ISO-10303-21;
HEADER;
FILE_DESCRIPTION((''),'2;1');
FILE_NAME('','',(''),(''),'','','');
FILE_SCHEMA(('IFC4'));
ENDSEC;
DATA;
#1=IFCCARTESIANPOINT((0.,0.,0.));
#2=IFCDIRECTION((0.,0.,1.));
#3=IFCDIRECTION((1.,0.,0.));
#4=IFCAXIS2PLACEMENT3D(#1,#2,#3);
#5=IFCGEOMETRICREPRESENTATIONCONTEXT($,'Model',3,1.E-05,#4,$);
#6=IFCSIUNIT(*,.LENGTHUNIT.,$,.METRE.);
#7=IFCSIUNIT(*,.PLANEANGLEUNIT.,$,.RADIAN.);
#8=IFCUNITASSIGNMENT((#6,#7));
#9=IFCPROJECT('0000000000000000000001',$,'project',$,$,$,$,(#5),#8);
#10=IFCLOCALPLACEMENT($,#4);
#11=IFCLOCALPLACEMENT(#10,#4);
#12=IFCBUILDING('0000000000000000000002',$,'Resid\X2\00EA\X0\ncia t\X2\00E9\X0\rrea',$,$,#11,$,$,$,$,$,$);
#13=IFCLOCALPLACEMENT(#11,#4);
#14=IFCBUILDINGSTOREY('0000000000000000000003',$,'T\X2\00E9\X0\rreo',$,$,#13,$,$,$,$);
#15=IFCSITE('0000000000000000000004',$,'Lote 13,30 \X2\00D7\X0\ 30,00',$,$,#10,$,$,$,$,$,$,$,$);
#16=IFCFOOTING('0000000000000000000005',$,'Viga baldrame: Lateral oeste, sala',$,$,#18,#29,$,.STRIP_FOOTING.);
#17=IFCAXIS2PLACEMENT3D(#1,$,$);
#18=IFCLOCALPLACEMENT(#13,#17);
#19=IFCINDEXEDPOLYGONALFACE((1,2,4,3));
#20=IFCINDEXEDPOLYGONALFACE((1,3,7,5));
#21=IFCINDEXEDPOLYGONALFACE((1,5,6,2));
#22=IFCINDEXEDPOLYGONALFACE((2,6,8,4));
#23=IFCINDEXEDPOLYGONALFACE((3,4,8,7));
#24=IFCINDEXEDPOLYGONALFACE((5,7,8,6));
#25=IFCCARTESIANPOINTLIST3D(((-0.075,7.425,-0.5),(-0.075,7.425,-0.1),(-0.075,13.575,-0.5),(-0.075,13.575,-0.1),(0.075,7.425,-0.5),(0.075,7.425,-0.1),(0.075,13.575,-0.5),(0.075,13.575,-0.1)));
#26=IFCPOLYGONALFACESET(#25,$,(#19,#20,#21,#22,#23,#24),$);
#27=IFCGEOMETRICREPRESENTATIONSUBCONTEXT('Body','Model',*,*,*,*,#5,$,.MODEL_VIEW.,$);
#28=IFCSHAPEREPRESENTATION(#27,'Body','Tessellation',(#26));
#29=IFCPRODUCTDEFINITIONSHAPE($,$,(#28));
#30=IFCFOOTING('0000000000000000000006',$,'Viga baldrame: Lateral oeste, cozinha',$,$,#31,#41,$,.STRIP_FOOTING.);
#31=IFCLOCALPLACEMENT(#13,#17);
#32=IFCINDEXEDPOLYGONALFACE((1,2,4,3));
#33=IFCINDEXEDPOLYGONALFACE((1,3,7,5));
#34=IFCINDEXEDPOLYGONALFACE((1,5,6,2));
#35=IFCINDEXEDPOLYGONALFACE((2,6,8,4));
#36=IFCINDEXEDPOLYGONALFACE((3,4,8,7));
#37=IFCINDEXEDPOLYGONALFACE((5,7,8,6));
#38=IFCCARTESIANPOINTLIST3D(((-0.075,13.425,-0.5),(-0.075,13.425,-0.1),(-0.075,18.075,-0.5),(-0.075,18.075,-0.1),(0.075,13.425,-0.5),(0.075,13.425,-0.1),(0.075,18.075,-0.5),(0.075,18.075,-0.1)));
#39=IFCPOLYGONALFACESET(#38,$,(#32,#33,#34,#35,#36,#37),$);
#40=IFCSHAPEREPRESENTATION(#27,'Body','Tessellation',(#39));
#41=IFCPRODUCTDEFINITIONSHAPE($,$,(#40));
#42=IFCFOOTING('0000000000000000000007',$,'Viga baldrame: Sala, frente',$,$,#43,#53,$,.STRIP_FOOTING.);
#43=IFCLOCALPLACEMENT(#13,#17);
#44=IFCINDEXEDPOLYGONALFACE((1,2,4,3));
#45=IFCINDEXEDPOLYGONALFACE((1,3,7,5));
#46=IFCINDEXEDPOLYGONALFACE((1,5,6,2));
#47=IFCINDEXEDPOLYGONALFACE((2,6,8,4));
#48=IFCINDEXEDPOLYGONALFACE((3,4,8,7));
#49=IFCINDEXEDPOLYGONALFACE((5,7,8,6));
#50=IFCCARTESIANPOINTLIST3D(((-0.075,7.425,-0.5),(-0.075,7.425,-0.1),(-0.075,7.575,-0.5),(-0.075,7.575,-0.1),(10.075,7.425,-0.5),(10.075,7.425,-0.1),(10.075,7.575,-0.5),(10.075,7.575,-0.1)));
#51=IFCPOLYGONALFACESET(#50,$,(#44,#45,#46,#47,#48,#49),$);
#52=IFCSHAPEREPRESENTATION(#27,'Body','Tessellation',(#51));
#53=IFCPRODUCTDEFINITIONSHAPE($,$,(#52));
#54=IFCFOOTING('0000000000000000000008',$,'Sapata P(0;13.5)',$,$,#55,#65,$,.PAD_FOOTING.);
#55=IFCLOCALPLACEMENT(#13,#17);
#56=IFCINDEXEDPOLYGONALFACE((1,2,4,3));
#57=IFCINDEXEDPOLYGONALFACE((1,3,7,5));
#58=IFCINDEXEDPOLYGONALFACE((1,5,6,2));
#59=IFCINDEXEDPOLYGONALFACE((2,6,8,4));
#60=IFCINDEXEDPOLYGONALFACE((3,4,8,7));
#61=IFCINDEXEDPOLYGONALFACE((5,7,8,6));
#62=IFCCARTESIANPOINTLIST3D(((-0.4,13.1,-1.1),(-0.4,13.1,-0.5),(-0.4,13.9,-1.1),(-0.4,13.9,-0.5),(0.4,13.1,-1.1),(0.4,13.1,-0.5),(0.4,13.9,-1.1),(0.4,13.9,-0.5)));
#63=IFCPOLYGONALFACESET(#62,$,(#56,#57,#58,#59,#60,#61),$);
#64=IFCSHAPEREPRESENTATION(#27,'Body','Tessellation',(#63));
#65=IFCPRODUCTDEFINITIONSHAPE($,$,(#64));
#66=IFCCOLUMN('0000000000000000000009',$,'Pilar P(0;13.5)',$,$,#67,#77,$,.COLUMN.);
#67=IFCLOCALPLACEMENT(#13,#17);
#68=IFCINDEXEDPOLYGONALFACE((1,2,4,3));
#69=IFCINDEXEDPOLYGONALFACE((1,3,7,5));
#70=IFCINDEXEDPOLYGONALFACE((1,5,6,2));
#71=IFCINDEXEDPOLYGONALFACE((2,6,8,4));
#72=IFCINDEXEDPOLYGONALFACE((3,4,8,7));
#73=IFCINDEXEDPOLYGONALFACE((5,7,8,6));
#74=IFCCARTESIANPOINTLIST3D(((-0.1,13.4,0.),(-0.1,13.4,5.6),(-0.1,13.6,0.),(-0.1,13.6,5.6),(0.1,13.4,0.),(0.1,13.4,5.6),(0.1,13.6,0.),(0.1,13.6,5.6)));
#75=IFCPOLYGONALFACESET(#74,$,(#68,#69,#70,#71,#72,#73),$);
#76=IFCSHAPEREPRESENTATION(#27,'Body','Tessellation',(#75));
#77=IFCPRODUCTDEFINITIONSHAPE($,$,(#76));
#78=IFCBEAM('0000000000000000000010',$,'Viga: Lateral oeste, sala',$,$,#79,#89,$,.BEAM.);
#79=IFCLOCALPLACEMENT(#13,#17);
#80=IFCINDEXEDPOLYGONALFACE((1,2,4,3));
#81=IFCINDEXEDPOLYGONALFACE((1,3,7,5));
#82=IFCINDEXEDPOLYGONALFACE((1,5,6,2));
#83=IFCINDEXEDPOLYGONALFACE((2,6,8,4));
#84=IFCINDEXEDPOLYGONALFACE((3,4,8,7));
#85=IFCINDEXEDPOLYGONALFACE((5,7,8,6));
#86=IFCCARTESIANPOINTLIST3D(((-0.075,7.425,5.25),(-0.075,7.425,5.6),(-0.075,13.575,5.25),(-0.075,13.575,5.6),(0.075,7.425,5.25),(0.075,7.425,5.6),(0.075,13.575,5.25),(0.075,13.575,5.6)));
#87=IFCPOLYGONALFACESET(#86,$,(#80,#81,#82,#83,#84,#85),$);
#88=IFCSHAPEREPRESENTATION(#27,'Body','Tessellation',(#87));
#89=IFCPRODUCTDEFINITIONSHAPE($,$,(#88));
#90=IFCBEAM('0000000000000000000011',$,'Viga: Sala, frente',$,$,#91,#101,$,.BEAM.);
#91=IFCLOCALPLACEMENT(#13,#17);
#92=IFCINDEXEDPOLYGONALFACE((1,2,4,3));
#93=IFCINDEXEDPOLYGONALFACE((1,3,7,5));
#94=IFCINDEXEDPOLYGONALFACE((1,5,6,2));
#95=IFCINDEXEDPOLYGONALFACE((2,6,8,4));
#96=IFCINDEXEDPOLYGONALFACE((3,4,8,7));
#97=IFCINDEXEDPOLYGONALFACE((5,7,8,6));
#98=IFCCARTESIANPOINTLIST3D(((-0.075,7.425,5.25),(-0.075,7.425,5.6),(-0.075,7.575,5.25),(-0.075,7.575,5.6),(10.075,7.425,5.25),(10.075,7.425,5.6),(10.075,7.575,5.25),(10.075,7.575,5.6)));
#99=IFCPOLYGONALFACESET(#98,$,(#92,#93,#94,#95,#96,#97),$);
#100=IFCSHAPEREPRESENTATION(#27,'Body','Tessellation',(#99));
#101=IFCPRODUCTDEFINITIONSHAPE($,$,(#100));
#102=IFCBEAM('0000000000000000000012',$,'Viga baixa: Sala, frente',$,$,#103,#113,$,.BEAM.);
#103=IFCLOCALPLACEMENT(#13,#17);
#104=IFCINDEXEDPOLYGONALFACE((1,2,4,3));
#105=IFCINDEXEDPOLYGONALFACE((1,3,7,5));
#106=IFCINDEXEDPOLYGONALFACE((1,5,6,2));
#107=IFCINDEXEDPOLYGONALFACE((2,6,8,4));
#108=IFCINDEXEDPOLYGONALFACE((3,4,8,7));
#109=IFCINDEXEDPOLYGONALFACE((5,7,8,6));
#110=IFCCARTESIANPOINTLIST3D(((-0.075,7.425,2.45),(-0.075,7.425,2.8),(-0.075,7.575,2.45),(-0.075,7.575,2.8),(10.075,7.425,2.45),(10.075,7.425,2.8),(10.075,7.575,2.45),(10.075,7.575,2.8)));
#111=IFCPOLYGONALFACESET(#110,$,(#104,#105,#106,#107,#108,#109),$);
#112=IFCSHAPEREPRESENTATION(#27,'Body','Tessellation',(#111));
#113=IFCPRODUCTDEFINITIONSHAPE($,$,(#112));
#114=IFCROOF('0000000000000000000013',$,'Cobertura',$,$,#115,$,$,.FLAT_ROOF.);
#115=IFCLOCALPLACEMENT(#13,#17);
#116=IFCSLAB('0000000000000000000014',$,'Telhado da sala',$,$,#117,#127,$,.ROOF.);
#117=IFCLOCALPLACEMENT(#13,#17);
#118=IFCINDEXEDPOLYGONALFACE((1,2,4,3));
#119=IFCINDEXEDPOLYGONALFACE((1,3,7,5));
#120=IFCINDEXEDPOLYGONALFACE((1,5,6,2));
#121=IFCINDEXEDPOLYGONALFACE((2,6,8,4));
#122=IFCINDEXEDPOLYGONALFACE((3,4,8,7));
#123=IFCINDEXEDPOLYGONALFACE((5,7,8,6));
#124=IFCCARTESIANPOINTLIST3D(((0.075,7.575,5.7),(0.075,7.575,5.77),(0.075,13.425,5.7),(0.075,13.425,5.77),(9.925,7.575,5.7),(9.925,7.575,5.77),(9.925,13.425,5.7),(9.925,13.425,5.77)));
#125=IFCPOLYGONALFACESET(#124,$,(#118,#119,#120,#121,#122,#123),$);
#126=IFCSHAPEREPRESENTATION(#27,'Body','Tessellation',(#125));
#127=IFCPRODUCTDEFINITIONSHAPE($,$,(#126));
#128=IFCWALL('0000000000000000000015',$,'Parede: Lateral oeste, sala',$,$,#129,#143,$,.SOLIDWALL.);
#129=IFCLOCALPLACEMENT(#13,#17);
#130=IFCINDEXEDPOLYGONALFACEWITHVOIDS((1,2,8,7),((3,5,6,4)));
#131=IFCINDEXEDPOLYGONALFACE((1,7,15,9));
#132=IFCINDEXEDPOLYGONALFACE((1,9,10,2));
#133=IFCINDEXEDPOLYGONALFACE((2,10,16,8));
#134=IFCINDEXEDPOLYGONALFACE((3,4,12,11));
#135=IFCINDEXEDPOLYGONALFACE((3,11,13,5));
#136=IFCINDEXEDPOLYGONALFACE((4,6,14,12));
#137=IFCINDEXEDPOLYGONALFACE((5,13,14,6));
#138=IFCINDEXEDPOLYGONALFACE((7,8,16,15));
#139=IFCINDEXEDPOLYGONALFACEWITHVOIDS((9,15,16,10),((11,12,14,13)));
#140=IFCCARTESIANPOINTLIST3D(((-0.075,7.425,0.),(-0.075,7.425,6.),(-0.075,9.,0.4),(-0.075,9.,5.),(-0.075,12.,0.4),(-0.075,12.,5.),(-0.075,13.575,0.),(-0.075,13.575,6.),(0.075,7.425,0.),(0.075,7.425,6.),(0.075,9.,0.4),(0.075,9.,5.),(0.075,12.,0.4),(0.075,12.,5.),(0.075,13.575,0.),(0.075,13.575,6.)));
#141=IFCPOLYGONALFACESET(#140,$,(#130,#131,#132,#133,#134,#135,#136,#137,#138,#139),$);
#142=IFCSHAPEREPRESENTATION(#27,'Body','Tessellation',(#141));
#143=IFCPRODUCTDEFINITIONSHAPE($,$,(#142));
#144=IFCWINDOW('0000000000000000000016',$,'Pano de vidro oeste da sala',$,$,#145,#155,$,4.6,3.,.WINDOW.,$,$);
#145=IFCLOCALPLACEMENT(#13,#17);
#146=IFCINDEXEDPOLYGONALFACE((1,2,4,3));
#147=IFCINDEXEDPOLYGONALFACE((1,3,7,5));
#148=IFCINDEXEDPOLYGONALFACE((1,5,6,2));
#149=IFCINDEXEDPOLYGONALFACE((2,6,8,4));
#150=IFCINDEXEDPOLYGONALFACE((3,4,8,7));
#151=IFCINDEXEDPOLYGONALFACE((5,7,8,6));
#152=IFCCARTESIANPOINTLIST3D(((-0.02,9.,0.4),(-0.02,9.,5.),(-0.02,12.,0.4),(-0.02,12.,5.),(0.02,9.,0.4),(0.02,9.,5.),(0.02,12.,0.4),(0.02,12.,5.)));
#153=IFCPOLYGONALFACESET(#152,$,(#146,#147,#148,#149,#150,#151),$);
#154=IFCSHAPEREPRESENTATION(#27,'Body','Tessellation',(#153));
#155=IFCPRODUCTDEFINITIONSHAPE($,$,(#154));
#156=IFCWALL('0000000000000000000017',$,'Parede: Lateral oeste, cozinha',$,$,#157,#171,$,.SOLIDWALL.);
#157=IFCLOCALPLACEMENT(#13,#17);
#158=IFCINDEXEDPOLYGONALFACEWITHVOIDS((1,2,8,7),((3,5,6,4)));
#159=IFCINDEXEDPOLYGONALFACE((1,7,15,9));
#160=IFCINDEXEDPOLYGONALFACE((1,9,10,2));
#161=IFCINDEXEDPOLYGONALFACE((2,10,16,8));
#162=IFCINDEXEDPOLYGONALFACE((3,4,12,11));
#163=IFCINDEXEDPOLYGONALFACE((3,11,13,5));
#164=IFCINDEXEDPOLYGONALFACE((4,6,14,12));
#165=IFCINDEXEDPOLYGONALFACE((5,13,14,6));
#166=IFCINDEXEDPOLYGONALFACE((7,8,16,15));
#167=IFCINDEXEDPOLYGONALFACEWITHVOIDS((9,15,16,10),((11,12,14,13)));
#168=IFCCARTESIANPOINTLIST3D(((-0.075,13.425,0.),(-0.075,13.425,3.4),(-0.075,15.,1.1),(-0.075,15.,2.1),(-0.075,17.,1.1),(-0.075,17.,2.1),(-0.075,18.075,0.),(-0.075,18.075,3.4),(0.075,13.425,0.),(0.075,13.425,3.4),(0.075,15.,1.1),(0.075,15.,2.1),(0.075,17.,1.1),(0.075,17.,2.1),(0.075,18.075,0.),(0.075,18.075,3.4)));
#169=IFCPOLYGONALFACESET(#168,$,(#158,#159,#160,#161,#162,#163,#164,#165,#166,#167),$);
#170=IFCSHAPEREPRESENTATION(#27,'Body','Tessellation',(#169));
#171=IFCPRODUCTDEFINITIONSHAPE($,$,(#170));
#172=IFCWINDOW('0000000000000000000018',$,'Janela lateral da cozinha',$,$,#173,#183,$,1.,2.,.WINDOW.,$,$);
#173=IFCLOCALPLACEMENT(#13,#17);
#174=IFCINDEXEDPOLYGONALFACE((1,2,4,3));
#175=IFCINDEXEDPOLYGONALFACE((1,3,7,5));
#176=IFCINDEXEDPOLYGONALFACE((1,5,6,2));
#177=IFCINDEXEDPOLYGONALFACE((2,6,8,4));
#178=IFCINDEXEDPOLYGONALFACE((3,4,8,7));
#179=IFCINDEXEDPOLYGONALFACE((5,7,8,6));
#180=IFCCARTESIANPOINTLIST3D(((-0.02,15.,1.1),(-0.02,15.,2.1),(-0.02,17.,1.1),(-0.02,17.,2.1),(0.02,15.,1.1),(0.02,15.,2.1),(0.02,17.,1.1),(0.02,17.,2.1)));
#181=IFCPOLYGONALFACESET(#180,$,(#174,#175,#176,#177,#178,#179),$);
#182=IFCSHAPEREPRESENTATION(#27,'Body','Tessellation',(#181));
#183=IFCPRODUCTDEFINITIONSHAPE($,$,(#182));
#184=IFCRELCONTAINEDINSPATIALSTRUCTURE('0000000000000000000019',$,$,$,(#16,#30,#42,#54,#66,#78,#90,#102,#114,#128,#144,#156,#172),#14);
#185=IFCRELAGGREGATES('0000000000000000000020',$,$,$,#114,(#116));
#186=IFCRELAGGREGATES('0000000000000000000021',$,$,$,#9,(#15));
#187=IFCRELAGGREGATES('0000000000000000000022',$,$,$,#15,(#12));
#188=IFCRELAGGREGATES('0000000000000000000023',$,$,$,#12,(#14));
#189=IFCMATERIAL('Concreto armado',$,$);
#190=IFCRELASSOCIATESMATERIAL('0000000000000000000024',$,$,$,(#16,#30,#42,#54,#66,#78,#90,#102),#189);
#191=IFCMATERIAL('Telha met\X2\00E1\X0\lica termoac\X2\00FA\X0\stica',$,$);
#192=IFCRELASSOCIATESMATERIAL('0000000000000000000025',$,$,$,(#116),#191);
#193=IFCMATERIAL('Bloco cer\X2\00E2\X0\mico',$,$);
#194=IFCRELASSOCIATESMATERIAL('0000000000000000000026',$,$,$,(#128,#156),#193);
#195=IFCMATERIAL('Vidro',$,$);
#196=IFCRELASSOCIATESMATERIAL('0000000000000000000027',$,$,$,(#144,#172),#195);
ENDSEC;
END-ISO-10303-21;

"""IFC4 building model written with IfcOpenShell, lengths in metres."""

from ifc_helpers import new_model, si_unit, frame, origin_with_axes, place, context, subcontext, project, spatial, line, indexed_curve, outline, extrude, material, element, fill, aggregate, save


model = new_model("IFC4")

# Units and contexts
model_context = context("Model", 3, precision=1e-05, world=origin_with_axes())
body_context = subcontext(model_context, "Body", "Model", "MODEL_VIEW")
ifc_project = project(units=[si_unit("LENGTHUNIT", "METRE"), si_unit("PLANEANGLEUNIT", "RADIAN")], contexts=[model_context])

# Site, building, storey
site_placement = place(None, origin_with_axes())
site = spatial("IfcSite", under=ifc_project, at=site_placement, Name="Lote 13,30 × 30,00")
building_placement = place(site_placement, origin_with_axes())
building = spatial("IfcBuilding", under=site, at=building_placement, Name="Residência térrea")
storey_placement = place(building_placement, origin_with_axes())
storey = spatial("IfcBuildingStorey", under=building, at=storey_placement, Name="Térreo")

# Footings
ifc_material_1 = material(Name="Concreto armado")
footing_1_placement = place(storey_placement, frame((-0.075, 7.425, -0.5), z_axis=(0.0, 0.0, 1.0), x_axis=(1.0, 0.0, 0.0)))
element("IfcFooting", 1, at=footing_1_placement, inside=storey, material=ifc_material_1, Name="Viga baldrame: Lateral oeste, sala", PredefinedType="STRIP_FOOTING", context=body_context, shape_type="SweptSolid", body=[
    extrude(outline(indexed_curve([(0.0, 0.0), (0.15, 0.0), (0.15, 6.15), (0.0, 6.15)], segments=[line(1, 2, 3, 4, 1)])), origin_with_axes(), (0.0, 0.0, 1.0), 0.4),
])
footing_2_placement = place(storey_placement, frame((-0.075, 13.425, -0.5), z_axis=(0.0, 0.0, 1.0), x_axis=(1.0, 0.0, 0.0)))
element("IfcFooting", 2, at=footing_2_placement, inside=storey, material=ifc_material_1, Name="Viga baldrame: Lateral oeste, cozinha", PredefinedType="STRIP_FOOTING", context=body_context, shape_type="SweptSolid", body=[
    extrude(outline(indexed_curve([(0.0, 0.0), (0.15, 0.0), (0.15, 4.65), (0.0, 4.65)], segments=[line(1, 2, 3, 4, 1)])), origin_with_axes(), (0.0, 0.0, 1.0), 0.4),
])
footing_3_placement = place(storey_placement, frame((-0.075, 7.425, -0.5), z_axis=(0.0, 0.0, 1.0), x_axis=(1.0, 0.0, 0.0)))
element("IfcFooting", 3, at=footing_3_placement, inside=storey, material=ifc_material_1, Name="Viga baldrame: Sala, frente", PredefinedType="STRIP_FOOTING", context=body_context, shape_type="SweptSolid", body=[
    extrude(outline(indexed_curve([(0.0, 0.0), (10.15, 0.0), (10.15, 0.15), (0.0, 0.15)], segments=[line(1, 2, 3, 4, 1)])), origin_with_axes(), (0.0, 0.0, 1.0), 0.4),
])
footing_4_placement = place(storey_placement, frame((-0.4, 13.1, -1.1), z_axis=(0.0, 0.0, 1.0), x_axis=(1.0, 0.0, 0.0)))
element("IfcFooting", 4, at=footing_4_placement, inside=storey, material=ifc_material_1, Name="Sapata P(0;13.5)", PredefinedType="PAD_FOOTING", context=body_context, shape_type="SweptSolid", body=[
    extrude(outline(indexed_curve([(0.0, 0.0), (0.8, 0.0), (0.8, 0.8), (0.0, 0.8)], segments=[line(1, 2, 3, 4, 1)])), origin_with_axes(), (0.0, 0.0, 1.0), 0.6),
])

# Column
column_placement = place(storey_placement, frame((-0.1, 13.4, 0.0), z_axis=(0.0, 0.0, 1.0), x_axis=(1.0, 0.0, 0.0)))
element("IfcColumn", 5, at=column_placement, inside=storey, material=ifc_material_1, Name="Pilar P(0;13.5)", PredefinedType="COLUMN", context=body_context, shape_type="SweptSolid", body=[
    extrude(outline(indexed_curve([(0.0, 0.0), (0.2, 0.0), (0.2, 0.2), (0.0, 0.2)], segments=[line(1, 2, 3, 4, 1)])), origin_with_axes(), (0.0, 0.0, 1.0), 5.6),
])

# Beams
beam_1_placement = place(storey_placement, frame((-0.075, 7.425, 5.25), z_axis=(0.0, 0.0, 1.0), x_axis=(1.0, 0.0, 0.0)))
element("IfcBeam", 6, at=beam_1_placement, inside=storey, material=ifc_material_1, Name="Viga: Lateral oeste, sala", PredefinedType="BEAM", context=body_context, shape_type="SweptSolid", body=[
    extrude(outline(indexed_curve([(0.0, 0.0), (0.15, 0.0), (0.15, 6.15), (0.0, 6.15)], segments=[line(1, 2, 3, 4, 1)])), origin_with_axes(), (0.0, 0.0, 1.0), 0.35),
])
beam_2_placement = place(storey_placement, frame((-0.075, 7.425, 5.25), z_axis=(0.0, 0.0, 1.0), x_axis=(1.0, 0.0, 0.0)))
element("IfcBeam", 7, at=beam_2_placement, inside=storey, material=ifc_material_1, Name="Viga: Sala, frente", PredefinedType="BEAM", context=body_context, shape_type="SweptSolid", body=[
    extrude(outline(indexed_curve([(0.0, 0.0), (10.15, 0.0), (10.15, 0.15), (0.0, 0.15)], segments=[line(1, 2, 3, 4, 1)])), origin_with_axes(), (0.0, 0.0, 1.0), 0.35),
])
beam_3_placement = place(storey_placement, frame((-0.075, 7.425, 2.45), z_axis=(0.0, 0.0, 1.0), x_axis=(1.0, 0.0, 0.0)))
element("IfcBeam", 8, at=beam_3_placement, inside=storey, material=ifc_material_1, Name="Viga baixa: Sala, frente", PredefinedType="BEAM", context=body_context, shape_type="SweptSolid", body=[
    extrude(outline(indexed_curve([(0.0, 0.0), (10.15, 0.0), (10.15, 0.15), (0.0, 0.15)], segments=[line(1, 2, 3, 4, 1)])), origin_with_axes(), (0.0, 0.0, 1.0), 0.35),
])

# Roof, slab
roof_placement = place(storey_placement, origin_with_axes())
roof = element("IfcRoof", 9, at=roof_placement, inside=storey, Name="Cobertura", PredefinedType="FLAT_ROOF")
ifc_material_2 = material(Name="Telha metálica termoacústica")
slab_placement = place(roof_placement, frame((0.075, 7.575, 5.7), z_axis=(0.0, 0.0, 1.0), x_axis=(1.0, 0.0, 0.0)))
slab = element("IfcSlab", 10, at=slab_placement, material=ifc_material_2, Name="Telhado da sala", PredefinedType="ROOF", context=body_context, shape_type="SweptSolid", body=[
    extrude(outline(indexed_curve([(0.0, 0.0), (9.85, 0.0), (9.85, 5.85), (0.0, 5.85)], segments=[line(1, 2, 3, 4, 1)])), origin_with_axes(), (0.0, 0.0, 1.0), 0.07),
])
aggregate(roof, [slab])

# Walls, openings, windows
ifc_material_3 = material(Name="Bloco cerâmico")
wall_1_placement = place(storey_placement, frame((-0.075, 7.425, 0.0), z_axis=(0.0, 0.0, 1.0), x_axis=(1.0, 0.0, 0.0)))
wall_1 = element("IfcWall", 11, at=wall_1_placement, inside=storey, material=ifc_material_3, Name="Parede: Lateral oeste, sala", PredefinedType="SOLIDWALL", context=body_context, shape_type="SweptSolid", body=[
    extrude(outline(indexed_curve([(0.0, 0.0), (0.15, 0.0), (0.15, 6.15), (0.0, 6.15)], segments=[line(1, 2, 3, 4, 1)])), origin_with_axes(), (0.0, 0.0, 1.0), 6.0),
])
opening_1_placement = place(wall_1_placement, frame((-0.05, 1.575, 0.4), z_axis=(0.0, 0.0, 1.0), x_axis=(1.0, 0.0, 0.0)))
opening_1 = element("IfcOpeningElement", 12, at=opening_1_placement, cuts=wall_1, material=ifc_material_1, PredefinedType="OPENING", context=body_context, shape_type="SweptSolid", body=[
    extrude(outline(indexed_curve([(0.0, 0.0), (0.25, 0.0), (0.25, 3.0), (0.0, 3.0)], segments=[line(1, 2, 3, 4, 1)])), origin_with_axes(), (0.0, 0.0, 1.0), 4.6),
])
ifc_material_4 = material(Name="Vidro")
window_1_placement = place(storey_placement, frame((-0.02, 9.0, 0.4), z_axis=(0.0, 0.0, 1.0), x_axis=(1.0, 0.0, 0.0)))
window_1 = element("IfcWindow", 13, at=window_1_placement, inside=storey, material=ifc_material_4, Name="Pano de vidro oeste da sala", OverallHeight=4.6, OverallWidth=3.0, PredefinedType="WINDOW", context=body_context, shape_type="SweptSolid", body=[
    extrude(outline(indexed_curve([(0.0, 0.0), (0.04, 0.0), (0.04, 3.0), (0.0, 3.0)], segments=[line(1, 2, 3, 4, 1)])), origin_with_axes(), (0.0, 0.0, 1.0), 4.6),
])
fill(opening_1, window_1)
wall_2_placement = place(storey_placement, frame((-0.075, 13.425, 0.0), z_axis=(0.0, 0.0, 1.0), x_axis=(1.0, 0.0, 0.0)))
wall_2 = element("IfcWall", 14, at=wall_2_placement, inside=storey, material=ifc_material_3, Name="Parede: Lateral oeste, cozinha", PredefinedType="SOLIDWALL", context=body_context, shape_type="SweptSolid", body=[
    extrude(outline(indexed_curve([(0.0, 0.0), (0.15, 0.0), (0.15, 4.65), (0.0, 4.65)], segments=[line(1, 2, 3, 4, 1)])), origin_with_axes(), (0.0, 0.0, 1.0), 3.4),
])
opening_2_placement = place(wall_2_placement, frame((-0.05, 1.575, 1.1), z_axis=(0.0, 0.0, 1.0), x_axis=(1.0, 0.0, 0.0)))
opening_2 = element("IfcOpeningElement", 15, at=opening_2_placement, cuts=wall_2, material=ifc_material_1, PredefinedType="OPENING", context=body_context, shape_type="SweptSolid", body=[
    extrude(outline(indexed_curve([(0.0, 0.0), (0.25, 0.0), (0.25, 2.0), (0.0, 2.0)], segments=[line(1, 2, 3, 4, 1)])), origin_with_axes(), (0.0, 0.0, 1.0), 1.0),
])
window_2_placement = place(storey_placement, frame((-0.02, 15.0, 1.1), z_axis=(0.0, 0.0, 1.0), x_axis=(1.0, 0.0, 0.0)))
window_2 = element("IfcWindow", 16, at=window_2_placement, inside=storey, material=ifc_material_4, Name="Janela lateral da cozinha", OverallHeight=1.0, OverallWidth=2.0, PredefinedType="WINDOW", context=body_context, shape_type="SweptSolid", body=[
    extrude(outline(indexed_curve([(0.0, 0.0), (0.04, 0.0), (0.04, 2.0), (0.0, 2.0)], segments=[line(1, 2, 3, 4, 1)])), origin_with_axes(), (0.0, 0.0, 1.0), 1.0),
])
fill(opening_2, window_2)

save(model, "model.ifc")
